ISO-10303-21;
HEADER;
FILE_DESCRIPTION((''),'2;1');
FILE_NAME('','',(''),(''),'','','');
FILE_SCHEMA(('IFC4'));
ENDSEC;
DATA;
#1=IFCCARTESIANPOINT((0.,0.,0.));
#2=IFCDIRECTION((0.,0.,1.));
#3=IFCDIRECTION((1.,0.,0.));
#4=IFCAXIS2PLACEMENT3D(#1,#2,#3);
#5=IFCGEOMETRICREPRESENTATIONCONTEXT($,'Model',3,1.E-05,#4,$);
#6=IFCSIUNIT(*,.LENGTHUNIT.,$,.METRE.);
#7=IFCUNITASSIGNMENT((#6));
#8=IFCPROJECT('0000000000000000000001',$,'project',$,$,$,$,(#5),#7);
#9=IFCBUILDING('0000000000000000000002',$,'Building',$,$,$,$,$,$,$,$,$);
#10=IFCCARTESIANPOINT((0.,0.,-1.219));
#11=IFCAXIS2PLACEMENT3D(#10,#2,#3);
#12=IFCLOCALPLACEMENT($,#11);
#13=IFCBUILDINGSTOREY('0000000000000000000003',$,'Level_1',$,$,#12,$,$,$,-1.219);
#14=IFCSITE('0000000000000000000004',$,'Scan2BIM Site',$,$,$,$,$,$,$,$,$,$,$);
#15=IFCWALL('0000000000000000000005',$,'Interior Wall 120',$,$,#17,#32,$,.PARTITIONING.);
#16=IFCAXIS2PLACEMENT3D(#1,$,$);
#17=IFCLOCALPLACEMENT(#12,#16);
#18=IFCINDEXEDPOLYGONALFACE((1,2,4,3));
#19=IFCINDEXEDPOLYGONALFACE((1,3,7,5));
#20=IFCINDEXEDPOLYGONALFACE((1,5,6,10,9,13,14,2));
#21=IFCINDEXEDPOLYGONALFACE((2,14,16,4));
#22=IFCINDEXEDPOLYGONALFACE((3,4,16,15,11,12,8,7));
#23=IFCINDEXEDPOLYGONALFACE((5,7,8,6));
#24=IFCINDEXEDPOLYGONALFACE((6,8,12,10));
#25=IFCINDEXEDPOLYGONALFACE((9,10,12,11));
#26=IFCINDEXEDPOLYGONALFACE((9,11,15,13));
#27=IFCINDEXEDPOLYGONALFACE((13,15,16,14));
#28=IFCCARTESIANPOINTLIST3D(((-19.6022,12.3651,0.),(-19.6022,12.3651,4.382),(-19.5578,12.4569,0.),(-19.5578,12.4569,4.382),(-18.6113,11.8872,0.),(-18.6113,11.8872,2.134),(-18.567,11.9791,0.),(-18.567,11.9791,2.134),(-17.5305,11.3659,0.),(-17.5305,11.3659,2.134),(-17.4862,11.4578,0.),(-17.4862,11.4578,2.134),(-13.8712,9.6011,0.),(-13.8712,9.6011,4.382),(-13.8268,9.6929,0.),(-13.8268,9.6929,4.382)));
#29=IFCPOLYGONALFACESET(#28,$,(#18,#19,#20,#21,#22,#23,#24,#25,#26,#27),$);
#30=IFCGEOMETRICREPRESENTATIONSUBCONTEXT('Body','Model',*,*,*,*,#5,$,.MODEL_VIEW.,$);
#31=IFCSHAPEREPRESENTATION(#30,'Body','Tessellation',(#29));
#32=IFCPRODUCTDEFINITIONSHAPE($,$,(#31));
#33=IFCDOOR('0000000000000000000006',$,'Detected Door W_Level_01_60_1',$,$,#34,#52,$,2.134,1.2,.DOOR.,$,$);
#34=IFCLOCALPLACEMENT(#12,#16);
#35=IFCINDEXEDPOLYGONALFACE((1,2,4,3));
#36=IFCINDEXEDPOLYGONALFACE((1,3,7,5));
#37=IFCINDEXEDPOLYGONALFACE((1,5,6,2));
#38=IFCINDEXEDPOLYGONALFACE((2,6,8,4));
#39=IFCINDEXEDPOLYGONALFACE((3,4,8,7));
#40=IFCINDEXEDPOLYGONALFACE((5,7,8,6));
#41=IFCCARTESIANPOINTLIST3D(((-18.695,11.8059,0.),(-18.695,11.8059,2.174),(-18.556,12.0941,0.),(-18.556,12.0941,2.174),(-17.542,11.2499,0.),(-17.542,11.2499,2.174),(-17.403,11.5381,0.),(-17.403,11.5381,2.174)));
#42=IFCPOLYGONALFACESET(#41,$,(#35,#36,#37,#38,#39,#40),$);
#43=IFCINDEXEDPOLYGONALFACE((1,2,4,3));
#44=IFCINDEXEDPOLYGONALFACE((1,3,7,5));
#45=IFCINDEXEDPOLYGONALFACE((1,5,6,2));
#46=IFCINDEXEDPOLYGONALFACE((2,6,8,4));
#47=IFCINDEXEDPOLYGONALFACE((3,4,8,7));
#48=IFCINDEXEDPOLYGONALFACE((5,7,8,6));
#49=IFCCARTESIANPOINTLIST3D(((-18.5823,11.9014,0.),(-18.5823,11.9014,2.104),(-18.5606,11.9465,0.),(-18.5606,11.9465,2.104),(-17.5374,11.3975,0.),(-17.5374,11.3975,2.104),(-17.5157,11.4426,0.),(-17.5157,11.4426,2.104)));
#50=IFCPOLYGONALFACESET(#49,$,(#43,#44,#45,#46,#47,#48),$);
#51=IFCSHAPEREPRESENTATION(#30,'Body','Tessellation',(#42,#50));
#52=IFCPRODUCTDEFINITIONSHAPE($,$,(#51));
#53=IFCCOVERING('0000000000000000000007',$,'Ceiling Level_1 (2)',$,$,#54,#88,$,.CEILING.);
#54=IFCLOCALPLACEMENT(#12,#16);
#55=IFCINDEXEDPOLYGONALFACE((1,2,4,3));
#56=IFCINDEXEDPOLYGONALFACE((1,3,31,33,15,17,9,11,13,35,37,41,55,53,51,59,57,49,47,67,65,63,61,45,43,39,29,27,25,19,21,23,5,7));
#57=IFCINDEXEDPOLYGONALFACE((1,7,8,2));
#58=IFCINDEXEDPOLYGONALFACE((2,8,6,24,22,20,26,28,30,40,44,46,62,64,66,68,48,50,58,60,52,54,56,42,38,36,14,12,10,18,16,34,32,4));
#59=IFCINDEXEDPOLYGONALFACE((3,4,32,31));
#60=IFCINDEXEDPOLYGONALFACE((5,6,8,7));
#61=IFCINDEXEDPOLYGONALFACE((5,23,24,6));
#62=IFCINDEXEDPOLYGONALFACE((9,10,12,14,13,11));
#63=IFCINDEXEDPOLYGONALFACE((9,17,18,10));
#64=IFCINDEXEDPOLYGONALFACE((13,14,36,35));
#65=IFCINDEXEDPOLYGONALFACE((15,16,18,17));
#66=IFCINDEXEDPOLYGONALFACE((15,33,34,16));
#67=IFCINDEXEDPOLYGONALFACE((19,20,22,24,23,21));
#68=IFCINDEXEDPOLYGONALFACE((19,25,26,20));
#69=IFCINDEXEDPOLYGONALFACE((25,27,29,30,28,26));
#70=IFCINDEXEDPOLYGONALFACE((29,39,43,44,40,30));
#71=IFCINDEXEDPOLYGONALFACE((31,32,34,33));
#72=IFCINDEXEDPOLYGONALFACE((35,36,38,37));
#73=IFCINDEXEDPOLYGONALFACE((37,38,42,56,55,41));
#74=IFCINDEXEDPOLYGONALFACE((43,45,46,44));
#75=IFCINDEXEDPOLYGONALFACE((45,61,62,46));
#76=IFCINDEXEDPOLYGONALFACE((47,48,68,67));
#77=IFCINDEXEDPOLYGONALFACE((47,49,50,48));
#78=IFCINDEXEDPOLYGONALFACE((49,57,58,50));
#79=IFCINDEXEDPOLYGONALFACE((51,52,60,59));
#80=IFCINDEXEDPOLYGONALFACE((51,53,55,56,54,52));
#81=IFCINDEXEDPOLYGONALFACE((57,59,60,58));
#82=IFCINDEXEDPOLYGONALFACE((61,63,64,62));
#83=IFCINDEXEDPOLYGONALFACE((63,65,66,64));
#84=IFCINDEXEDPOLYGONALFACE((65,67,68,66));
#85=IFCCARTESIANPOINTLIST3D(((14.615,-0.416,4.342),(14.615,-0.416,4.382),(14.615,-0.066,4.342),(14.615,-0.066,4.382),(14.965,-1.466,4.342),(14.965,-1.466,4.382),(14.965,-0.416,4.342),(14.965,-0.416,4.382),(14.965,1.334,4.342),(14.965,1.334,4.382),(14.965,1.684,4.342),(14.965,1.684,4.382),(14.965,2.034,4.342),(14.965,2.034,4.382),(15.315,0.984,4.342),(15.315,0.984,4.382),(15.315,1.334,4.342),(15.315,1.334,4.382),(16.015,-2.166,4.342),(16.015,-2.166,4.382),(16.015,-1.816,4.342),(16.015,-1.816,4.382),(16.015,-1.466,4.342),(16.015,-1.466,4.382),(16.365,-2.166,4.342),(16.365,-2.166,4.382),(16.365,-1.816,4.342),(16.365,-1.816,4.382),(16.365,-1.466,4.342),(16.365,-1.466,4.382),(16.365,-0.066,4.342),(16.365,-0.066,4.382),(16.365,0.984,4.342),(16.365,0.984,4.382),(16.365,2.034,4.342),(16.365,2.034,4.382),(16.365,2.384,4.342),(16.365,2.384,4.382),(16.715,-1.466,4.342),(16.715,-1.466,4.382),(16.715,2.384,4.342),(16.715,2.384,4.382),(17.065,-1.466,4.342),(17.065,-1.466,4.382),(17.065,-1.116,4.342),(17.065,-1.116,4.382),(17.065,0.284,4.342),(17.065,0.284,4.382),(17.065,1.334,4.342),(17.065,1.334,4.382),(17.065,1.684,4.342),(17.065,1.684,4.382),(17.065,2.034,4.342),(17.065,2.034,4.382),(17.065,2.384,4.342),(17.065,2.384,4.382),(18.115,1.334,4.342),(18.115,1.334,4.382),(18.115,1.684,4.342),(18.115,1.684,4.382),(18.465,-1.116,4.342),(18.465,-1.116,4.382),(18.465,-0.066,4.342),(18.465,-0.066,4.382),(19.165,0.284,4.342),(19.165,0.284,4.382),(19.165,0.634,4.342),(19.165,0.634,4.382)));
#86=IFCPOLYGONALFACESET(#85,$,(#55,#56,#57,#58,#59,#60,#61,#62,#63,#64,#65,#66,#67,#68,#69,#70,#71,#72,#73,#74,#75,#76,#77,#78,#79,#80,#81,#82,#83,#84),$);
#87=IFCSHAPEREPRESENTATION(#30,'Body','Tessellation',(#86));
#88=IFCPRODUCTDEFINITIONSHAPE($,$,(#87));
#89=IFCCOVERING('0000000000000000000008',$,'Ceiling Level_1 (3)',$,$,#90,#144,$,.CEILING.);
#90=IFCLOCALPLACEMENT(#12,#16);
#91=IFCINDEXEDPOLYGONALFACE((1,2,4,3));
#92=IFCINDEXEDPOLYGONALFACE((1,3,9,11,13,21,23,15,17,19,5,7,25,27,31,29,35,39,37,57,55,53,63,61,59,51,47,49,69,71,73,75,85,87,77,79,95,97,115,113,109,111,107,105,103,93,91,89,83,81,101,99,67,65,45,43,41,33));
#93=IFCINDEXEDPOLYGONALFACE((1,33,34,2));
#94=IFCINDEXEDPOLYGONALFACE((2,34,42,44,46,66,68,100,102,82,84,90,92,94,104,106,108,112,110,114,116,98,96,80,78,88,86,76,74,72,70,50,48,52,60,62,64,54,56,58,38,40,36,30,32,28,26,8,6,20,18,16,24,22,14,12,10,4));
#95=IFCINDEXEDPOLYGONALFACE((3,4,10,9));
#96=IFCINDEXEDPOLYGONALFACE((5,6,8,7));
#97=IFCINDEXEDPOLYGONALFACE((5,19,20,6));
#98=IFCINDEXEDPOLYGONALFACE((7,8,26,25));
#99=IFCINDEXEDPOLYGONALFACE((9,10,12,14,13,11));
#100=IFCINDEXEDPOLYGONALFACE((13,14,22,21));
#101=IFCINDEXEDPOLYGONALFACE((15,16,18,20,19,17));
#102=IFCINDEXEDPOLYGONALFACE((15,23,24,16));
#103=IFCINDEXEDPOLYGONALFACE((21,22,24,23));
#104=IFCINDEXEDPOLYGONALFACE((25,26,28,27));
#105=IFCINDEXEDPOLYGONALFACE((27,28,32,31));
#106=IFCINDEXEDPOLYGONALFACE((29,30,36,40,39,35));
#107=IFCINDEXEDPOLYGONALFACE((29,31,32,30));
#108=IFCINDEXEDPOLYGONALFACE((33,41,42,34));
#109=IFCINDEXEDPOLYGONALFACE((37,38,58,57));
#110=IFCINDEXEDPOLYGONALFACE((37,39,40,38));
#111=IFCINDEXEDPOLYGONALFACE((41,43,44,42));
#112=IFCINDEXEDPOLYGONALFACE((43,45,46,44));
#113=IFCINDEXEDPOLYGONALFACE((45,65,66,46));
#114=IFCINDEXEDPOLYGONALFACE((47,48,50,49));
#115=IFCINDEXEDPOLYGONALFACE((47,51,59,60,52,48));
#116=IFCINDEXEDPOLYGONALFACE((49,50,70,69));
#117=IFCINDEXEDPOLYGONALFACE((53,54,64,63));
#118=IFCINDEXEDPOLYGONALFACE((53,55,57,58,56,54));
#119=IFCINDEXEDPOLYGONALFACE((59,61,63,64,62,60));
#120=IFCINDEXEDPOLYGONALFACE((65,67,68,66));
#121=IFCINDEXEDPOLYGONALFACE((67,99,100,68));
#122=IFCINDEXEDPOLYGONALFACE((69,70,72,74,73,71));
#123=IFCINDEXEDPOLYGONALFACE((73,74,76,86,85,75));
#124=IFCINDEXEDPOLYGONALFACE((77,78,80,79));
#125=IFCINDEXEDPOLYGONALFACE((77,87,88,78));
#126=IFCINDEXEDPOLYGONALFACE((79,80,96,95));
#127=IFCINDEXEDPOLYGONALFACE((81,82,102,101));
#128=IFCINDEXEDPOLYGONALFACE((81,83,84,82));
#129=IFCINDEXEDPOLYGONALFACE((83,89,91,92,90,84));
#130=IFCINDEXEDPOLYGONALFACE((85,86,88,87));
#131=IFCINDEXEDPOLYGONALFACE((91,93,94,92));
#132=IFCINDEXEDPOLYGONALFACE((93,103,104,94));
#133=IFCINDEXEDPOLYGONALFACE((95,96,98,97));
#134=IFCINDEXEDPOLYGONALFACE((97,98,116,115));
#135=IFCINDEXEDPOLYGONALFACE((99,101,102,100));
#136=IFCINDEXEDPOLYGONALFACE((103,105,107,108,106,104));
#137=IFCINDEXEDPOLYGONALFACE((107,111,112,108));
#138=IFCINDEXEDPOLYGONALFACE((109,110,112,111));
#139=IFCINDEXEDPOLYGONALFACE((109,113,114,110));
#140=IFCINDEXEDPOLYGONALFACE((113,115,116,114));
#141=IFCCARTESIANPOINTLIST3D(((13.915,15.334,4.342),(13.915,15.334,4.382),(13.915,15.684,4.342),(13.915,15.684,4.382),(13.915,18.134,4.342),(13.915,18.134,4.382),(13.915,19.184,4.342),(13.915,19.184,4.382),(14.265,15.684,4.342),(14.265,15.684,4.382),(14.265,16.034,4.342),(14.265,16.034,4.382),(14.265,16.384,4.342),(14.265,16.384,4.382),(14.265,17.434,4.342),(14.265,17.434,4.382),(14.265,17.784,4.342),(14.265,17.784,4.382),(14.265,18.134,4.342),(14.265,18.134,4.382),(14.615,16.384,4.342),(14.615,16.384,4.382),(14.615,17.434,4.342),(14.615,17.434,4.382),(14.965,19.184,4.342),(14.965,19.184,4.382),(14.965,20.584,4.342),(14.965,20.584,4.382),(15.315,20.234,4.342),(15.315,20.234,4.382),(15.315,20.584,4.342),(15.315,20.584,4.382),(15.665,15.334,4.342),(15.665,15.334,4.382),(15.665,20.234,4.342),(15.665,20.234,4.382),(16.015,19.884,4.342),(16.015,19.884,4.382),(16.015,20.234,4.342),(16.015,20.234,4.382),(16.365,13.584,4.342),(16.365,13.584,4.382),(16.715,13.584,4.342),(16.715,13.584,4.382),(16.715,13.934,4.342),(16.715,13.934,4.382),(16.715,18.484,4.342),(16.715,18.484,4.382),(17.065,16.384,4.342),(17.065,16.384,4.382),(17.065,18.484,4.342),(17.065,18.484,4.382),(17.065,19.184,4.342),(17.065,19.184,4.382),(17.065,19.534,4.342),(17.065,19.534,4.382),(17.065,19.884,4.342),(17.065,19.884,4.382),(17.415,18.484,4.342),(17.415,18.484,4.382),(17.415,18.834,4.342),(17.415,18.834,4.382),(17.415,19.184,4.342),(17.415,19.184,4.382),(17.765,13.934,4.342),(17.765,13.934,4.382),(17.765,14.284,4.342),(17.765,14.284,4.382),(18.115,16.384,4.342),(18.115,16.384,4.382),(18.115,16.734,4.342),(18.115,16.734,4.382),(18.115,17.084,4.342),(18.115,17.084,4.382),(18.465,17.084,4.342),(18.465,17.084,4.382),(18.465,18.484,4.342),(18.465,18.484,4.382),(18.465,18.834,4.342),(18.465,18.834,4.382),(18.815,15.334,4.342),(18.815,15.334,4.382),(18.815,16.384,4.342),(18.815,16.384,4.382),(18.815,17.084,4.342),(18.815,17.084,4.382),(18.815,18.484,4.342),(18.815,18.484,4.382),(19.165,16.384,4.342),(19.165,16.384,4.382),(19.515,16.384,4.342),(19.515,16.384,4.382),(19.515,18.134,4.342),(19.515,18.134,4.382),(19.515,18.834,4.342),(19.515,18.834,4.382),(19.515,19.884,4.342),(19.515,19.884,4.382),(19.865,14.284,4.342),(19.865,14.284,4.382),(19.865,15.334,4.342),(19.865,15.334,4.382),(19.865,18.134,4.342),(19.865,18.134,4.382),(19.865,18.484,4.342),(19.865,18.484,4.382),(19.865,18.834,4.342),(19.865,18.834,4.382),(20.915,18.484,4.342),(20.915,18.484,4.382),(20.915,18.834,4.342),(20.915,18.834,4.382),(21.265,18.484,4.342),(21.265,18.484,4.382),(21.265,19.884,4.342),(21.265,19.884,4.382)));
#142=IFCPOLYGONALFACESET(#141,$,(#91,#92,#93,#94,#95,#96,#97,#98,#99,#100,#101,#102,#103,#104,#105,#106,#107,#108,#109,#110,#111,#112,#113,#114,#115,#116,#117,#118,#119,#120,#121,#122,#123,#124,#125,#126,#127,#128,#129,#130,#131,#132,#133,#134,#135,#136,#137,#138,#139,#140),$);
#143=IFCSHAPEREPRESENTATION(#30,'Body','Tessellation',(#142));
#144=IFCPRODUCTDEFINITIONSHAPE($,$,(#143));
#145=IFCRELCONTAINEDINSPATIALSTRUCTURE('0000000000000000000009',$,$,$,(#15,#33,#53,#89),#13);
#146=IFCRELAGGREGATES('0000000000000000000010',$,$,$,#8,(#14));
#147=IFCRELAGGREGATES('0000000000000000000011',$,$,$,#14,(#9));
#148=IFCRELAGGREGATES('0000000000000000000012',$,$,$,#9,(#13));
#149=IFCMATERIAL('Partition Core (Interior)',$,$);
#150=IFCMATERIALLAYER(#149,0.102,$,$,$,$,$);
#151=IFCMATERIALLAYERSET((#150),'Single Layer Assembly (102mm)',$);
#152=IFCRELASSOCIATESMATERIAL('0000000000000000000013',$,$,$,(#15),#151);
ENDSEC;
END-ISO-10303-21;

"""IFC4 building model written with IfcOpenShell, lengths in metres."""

from ifc_helpers import new_model, si_unit, frame, origin, origin_with_axes, place, context, subcontext, project, spatial, polyline, rectangle, outline, extrude, material, layer, layer_set, element, fill, save


model = new_model("IFC4")

# Units and contexts
model_context = context("Model", 3, precision=1e-05, world=origin_with_axes())
body_context = subcontext(model_context, "Body", "Model", "MODEL_VIEW")
ifc_project = project(units=[si_unit("LENGTHUNIT", "METRE")], contexts=[model_context])

# Site, building, storey
site = spatial("IfcSite", under=ifc_project, Name="Scan2BIM Site")
building = spatial("IfcBuilding", under=site, Name="Building")
storey_placement = place(None, frame((0.0, 0.0, -1.219), z_axis=(0.0, 0.0, 1.0), x_axis=(1.0, 0.0, 0.0)))
storey = spatial("IfcBuildingStorey", under=building, at=storey_placement, Name="Level_1", Elevation=-1.219)

# Wall, opening, door
ifc_material_1 = material(Name="Partition Core (Interior)")
ifc_layer_1 = layer(ifc_material_1, 0.102)
ifc_layer_set_1 = layer_set([ifc_layer_1], Name="Single Layer Assembly (102mm)")
wall_1_placement = place(storey_placement, frame((-16.7145, 11.029, 0.0), z_axis=(0.0, 0.0, 1.0), x_axis=(0.900717, -0.434406, 0.0)))
wall_1 = element("IfcWall", 1, at=wall_1_placement, inside=storey, material=ifc_layer_set_1, Name="Interior Wall 120", PredefinedType="PARTITIONING", context=body_context, shape_type="SweptSolid", body=[
    extrude(rectangle(XDim=6.3627, YDim=0.102), origin(), (0.0, 0.0, 1.0), 4.382),
])
opening_1_placement = place(None, frame((-18.049, 11.672, -1.219), z_axis=(0.0, 0.0, 1.0), x_axis=(0.900717, -0.434406, 0.0)))
opening_1 = element("IfcOpeningElement", 2, at=opening_1_placement, cuts=wall_1, PredefinedType="OPENING", context=body_context, shape_type="SweptSolid", body=[
    extrude(rectangle(XDim=1.2, YDim=0.202), origin(), (0.0, 0.0, 1.0), 2.134),
])
door_1_placement = place(opening_1_placement, frame((0.0, 0.0, 0.0), z_axis=(0.0, 0.0, 1.0), x_axis=(1.0, 0.0, 0.0)))
door_1 = element("IfcDoor", 3, at=door_1_placement, inside=storey, Name="Detected Door W_Level_01_60_1", OverallHeight=2.134, OverallWidth=1.2, PredefinedType="DOOR", context=body_context, shape_type="SweptSolid", body=[
    extrude(rectangle(XDim=1.28, YDim=0.32), origin(), (0.0, 0.0, 1.0), 2.174),
    extrude(rectangle(XDim=1.16, YDim=0.05), origin(), (0.0, 0.0, 1.0), 2.104),
])
fill(opening_1, door_1)

# Coverings
covering_1_placement = place(storey_placement, frame((0.0, 0.0, 4.342), z_axis=(0.0, 0.0, 1.0), x_axis=(1.0, 0.0, 0.0)))
element("IfcCovering", 4, at=covering_1_placement, inside=storey, Name="Ceiling Level_1 (2)", PredefinedType="CEILING", context=body_context, shape_type="SweptSolid", body=[
    extrude(outline(polyline([(16.015, -2.166), (16.365, -2.166), (16.365, -1.816), (16.365, -1.466), (16.715, -1.466), (17.065, -1.466), (17.065, -1.116), (18.465, -1.116), (18.465, -0.066), (19.165, 0.284), (19.165, 0.634), (17.065, 0.284), (17.065, 1.334), (18.115, 1.334), (18.115, 1.684), (17.065, 1.684), (17.065, 2.034), (17.065, 2.384), (16.715, 2.384), (16.365, 2.384), (16.365, 2.034), (14.965, 2.034), (14.965, 1.684), (14.965, 1.334), (15.315, 1.334), (15.315, 0.984), (16.365, 0.984), (16.365, -0.066), (14.615, -0.066), (14.615, -0.416), (14.965, -0.416), (14.965, -1.466), (16.015, -1.466), (16.015, -1.816), (16.015, -2.166)])), origin(), (0.0, 0.0, 1.0), 0.04),
])
covering_2_placement = place(storey_placement, frame((0.0, 0.0, 4.342), z_axis=(0.0, 0.0, 1.0), x_axis=(1.0, 0.0, 0.0)))
element("IfcCovering", 5, at=covering_2_placement, inside=storey, Name="Ceiling Level_1 (3)", PredefinedType="CEILING", context=body_context, shape_type="SweptSolid", body=[
    extrude(outline(polyline([(16.365, 13.584), (16.715, 13.584), (16.715, 13.934), (17.765, 13.934), (17.765, 14.284), (19.865, 14.284), (19.865, 15.334), (18.815, 15.334), (18.815, 16.384), (19.165, 16.384), (19.515, 16.384), (19.515, 18.134), (19.865, 18.134), (19.865, 18.484), (19.865, 18.834), (20.915, 18.834), (20.915, 18.484), (21.265, 18.484), (21.265, 19.884), (19.515, 19.884), (19.515, 18.834), (18.465, 18.834), (18.465, 18.484), (18.815, 18.484), (18.815, 17.084), (18.465, 17.084), (18.115, 17.084), (18.115, 16.734), (18.115, 16.384), (17.065, 16.384), (16.715, 18.484), (17.065, 18.484), (17.415, 18.484), (17.415, 18.834), (17.415, 19.184), (17.065, 19.184), (17.065, 19.534), (17.065, 19.884), (16.015, 19.884), (16.015, 20.234), (15.665, 20.234), (15.315, 20.234), (15.315, 20.584), (14.965, 20.584), (14.965, 19.184), (13.915, 19.184), (13.915, 18.134), (14.265, 18.134), (14.265, 17.784), (14.265, 17.434), (14.615, 17.434), (14.615, 16.384), (14.265, 16.384), (14.265, 16.034), (14.265, 15.684), (13.915, 15.684), (13.915, 15.334), (15.665, 15.334), (16.365, 13.584)])), origin(), (0.0, 0.0, 1.0), 0.04),
])

save(model, "model.ifc")
